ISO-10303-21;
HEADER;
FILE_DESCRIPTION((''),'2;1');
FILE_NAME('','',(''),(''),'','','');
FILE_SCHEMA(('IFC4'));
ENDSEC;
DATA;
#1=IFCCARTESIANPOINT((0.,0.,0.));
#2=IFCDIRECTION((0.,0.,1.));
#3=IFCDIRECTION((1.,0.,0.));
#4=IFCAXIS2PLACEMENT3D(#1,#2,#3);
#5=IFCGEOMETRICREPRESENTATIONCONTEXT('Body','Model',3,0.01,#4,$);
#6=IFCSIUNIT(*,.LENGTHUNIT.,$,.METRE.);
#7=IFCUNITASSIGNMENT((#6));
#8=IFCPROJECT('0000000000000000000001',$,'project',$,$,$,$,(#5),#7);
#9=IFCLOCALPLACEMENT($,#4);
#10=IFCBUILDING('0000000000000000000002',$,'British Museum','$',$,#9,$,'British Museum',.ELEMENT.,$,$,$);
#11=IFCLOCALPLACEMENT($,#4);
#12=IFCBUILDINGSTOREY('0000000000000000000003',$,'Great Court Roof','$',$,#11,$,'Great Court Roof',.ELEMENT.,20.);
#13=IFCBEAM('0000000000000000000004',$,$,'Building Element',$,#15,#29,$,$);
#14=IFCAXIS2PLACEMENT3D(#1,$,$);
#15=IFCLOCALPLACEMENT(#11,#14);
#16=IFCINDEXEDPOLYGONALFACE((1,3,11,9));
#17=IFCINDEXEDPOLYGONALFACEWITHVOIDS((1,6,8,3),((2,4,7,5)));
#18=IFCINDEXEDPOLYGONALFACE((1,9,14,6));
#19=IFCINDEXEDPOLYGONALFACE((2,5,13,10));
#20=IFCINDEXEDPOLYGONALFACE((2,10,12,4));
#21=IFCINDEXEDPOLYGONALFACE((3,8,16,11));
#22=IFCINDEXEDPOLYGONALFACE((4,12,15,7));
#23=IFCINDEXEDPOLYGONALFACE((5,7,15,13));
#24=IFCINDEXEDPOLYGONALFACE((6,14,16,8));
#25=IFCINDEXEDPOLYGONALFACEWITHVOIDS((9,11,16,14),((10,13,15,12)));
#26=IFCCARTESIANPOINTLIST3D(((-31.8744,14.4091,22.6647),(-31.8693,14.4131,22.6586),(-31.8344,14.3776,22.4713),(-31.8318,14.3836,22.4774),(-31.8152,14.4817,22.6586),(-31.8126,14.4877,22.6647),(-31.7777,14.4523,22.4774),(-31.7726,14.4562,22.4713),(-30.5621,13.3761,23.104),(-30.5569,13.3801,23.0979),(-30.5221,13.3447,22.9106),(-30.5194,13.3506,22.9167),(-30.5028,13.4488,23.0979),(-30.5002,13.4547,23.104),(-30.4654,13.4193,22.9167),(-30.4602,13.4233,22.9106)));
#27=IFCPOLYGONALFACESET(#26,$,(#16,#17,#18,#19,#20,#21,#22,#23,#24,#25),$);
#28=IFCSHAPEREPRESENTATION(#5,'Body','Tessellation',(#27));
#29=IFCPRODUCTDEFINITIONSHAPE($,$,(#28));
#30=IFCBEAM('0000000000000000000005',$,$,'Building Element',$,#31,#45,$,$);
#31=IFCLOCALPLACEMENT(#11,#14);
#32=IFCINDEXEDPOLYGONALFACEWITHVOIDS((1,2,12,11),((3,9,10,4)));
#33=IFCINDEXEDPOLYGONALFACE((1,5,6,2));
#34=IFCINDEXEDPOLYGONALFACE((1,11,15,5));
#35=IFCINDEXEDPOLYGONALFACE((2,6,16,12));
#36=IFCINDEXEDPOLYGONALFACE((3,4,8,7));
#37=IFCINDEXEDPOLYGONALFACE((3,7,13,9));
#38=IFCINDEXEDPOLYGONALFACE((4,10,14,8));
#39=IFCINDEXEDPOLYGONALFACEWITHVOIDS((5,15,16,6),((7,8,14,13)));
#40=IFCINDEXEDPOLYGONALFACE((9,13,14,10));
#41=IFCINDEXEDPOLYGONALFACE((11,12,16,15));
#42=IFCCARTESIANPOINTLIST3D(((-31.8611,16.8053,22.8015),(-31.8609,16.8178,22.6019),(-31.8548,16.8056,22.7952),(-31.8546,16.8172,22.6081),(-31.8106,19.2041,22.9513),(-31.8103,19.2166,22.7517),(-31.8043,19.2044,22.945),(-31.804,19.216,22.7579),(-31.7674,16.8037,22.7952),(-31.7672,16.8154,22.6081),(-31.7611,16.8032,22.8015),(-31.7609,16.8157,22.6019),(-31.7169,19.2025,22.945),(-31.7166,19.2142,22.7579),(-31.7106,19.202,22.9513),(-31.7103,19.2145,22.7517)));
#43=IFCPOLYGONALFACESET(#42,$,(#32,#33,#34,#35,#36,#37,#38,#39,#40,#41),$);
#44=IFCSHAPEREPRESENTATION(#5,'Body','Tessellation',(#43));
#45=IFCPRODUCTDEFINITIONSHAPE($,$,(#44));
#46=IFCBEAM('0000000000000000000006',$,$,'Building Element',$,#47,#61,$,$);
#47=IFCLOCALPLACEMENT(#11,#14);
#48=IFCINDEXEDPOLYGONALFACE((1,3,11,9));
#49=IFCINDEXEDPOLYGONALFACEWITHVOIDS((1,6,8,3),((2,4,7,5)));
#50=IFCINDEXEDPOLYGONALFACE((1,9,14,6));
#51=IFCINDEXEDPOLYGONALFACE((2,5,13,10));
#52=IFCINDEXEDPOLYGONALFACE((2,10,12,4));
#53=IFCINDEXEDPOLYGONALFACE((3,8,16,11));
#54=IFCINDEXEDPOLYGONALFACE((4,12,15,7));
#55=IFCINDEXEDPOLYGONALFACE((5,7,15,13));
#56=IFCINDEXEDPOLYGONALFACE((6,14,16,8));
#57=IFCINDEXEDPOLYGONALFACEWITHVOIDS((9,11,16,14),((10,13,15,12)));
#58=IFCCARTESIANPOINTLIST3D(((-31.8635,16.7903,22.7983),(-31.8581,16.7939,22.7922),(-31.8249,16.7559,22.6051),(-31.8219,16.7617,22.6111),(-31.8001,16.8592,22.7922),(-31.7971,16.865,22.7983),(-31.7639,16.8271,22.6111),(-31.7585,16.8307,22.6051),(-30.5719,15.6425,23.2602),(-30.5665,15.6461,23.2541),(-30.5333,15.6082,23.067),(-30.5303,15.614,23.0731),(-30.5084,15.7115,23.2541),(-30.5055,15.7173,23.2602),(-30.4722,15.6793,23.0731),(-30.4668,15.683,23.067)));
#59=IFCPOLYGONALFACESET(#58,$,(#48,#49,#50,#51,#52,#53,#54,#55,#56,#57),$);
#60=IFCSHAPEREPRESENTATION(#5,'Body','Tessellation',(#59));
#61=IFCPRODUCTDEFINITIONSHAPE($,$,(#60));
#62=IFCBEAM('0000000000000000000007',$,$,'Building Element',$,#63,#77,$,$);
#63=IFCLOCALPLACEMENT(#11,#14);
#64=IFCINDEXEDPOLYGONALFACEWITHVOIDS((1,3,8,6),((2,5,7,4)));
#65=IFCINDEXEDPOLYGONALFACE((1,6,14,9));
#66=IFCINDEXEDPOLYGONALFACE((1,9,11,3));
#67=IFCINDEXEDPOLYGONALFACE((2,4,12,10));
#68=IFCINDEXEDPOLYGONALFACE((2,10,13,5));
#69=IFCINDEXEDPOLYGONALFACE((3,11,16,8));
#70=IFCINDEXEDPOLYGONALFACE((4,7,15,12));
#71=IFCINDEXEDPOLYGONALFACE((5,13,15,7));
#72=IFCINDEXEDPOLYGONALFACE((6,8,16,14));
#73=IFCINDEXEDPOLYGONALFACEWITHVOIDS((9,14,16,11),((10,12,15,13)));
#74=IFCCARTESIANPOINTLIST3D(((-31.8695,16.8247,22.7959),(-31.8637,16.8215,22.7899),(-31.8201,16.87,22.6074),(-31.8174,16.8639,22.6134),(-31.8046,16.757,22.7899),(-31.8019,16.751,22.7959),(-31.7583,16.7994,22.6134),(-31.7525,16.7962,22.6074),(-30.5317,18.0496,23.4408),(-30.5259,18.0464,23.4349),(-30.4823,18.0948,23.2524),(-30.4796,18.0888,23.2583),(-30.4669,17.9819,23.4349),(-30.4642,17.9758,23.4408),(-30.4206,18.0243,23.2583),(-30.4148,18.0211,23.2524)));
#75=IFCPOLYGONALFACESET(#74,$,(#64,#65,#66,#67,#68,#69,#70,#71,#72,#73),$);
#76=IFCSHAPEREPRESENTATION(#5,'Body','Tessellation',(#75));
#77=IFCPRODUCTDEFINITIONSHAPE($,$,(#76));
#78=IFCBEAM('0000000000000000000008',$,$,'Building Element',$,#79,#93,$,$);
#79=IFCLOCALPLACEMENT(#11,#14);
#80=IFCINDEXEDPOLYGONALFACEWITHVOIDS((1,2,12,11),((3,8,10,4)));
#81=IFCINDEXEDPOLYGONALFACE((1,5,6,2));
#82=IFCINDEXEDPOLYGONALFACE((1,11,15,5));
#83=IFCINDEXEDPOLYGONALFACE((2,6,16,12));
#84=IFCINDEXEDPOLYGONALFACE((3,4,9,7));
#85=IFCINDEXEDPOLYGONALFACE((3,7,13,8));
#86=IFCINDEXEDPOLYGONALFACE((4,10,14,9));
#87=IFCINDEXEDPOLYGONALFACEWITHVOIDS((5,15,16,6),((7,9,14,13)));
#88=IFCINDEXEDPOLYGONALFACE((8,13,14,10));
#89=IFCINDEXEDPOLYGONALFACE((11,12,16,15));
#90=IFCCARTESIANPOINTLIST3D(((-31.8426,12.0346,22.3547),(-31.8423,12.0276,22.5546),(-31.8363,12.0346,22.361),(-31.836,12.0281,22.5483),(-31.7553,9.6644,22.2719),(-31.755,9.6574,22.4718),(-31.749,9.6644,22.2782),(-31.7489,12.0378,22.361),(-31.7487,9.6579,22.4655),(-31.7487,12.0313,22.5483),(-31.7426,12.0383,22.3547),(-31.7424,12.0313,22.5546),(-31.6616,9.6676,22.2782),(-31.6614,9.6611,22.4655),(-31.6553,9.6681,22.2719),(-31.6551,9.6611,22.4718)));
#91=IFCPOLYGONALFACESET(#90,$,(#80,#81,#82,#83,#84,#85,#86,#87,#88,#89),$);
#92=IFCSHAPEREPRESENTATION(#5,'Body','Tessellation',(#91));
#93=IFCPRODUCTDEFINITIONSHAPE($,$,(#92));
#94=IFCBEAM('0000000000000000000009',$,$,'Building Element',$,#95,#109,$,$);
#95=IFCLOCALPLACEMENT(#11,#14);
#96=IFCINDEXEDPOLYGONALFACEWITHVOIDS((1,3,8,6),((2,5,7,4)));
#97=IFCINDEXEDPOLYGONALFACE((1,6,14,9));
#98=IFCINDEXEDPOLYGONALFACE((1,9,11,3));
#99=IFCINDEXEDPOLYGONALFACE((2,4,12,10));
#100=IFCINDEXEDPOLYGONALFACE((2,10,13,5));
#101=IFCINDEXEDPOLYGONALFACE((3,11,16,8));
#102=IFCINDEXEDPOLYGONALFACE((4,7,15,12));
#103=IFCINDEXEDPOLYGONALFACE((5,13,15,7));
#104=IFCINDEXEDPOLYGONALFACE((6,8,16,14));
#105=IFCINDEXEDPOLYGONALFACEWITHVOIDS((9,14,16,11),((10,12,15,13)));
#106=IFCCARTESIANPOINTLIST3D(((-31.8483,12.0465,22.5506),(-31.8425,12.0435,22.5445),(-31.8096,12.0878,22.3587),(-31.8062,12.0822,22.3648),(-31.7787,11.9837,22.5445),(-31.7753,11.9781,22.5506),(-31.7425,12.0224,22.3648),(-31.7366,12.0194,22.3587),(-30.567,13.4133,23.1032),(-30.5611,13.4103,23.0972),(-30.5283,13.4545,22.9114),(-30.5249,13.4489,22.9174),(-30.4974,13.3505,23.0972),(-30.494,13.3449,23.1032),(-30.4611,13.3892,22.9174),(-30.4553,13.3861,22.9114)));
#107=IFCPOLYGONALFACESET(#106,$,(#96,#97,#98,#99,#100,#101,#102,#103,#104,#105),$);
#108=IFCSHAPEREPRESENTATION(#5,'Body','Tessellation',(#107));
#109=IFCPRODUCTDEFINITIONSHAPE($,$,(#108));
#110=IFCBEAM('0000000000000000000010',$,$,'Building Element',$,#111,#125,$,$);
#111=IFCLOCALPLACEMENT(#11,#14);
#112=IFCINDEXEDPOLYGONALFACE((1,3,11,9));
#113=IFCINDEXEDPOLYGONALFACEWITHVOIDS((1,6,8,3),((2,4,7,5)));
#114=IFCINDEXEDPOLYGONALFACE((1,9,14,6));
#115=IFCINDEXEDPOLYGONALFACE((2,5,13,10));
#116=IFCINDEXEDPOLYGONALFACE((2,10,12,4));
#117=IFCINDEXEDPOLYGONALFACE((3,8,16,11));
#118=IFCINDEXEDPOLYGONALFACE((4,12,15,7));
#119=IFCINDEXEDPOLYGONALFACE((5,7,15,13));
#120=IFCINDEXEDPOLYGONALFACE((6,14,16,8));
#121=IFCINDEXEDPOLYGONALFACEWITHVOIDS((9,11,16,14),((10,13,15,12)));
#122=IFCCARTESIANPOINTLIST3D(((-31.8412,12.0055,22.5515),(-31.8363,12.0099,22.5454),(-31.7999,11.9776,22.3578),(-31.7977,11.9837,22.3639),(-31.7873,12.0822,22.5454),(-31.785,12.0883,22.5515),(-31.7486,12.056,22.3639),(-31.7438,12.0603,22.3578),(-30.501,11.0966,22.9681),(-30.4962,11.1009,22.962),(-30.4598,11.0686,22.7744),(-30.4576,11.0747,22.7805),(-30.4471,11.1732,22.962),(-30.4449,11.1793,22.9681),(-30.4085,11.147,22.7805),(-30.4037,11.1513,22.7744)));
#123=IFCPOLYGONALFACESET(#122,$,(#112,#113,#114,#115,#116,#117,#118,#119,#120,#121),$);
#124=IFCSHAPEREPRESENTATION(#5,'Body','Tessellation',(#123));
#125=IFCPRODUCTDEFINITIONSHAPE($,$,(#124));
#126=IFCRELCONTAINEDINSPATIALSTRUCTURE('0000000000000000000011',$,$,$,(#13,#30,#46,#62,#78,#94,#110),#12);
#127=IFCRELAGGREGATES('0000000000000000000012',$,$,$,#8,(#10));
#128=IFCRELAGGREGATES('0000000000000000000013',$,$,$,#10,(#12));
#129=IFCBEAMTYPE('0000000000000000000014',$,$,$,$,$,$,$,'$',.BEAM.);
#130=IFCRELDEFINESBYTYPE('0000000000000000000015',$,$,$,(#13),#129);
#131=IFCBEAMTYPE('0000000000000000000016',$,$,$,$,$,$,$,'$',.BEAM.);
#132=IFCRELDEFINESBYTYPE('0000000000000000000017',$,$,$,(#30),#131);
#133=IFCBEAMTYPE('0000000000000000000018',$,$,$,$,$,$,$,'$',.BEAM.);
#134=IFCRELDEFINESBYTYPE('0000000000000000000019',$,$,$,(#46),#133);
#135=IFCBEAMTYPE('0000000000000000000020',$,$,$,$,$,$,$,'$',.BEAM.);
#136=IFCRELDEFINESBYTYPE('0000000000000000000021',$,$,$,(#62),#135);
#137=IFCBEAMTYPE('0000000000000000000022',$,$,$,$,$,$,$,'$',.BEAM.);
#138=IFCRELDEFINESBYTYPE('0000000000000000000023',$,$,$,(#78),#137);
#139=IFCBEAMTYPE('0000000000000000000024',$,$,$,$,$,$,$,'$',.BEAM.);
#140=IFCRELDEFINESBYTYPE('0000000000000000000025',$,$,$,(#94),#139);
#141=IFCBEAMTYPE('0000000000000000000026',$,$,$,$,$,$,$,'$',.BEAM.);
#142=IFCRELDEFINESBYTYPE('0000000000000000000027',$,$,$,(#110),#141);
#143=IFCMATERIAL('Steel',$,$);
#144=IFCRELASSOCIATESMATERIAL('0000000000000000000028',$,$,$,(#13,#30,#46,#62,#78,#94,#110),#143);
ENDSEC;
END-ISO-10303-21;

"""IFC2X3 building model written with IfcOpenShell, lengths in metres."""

from ifc_helpers import new_model, si_unit, frame, origin_with_axes, origin_2d, place, context, project, spatial, hollow_rectangle, extrude, material, type_object, element, save


model = new_model("IFC2X3")

# Units and contexts
model_context = context("Model", 3, precision=0.01, world=origin_with_axes(), identifier="Body")
ifc_project = project(units=[si_unit("LENGTHUNIT", "METRE")], contexts=[model_context])

# Building, storey
building_placement = place(None, origin_with_axes())
building = spatial("IfcBuilding", under=ifc_project, at=building_placement, Name="British Museum", Description="$", LongName="British Museum", CompositionType="ELEMENT")
storey_placement = place(None, origin_with_axes())
storey = spatial("IfcBuildingStorey", under=building, at=storey_placement, Name="Great Court Roof", Description="$", LongName="Great Court Roof", CompositionType="ELEMENT", Elevation=20.0)

# Beams
ifc_material = material(Name="Steel")
beam_type_1 = type_object("IfcBeamType", ElementType="$", PredefinedType="BEAM")
beam_1_placement = place(None, origin_with_axes())
element("IfcBeam", 1, at=beam_1_placement, inside=storey, type_object=beam_type_1, material=ifc_material, Description="Building Element", context=model_context, shape_type="SweptSolid", body=[
    extrude(hollow_rectangle(XDim=0.1, YDim=0.2, WallThickness=0.0063, InnerFilletRadius=-0.0063, OuterFilletRadius=0.0, at=origin_2d()), frame((-31.8235, 14.4327, 22.568), z_axis=(0.759942, -0.598145, 0.254385), x_axis=(0.618491, 0.785792, 0.0)), (0.0, 0.0, 1.0), 1.7269),
])
beam_type_2 = type_object("IfcBeamType", ElementType="$", PredefinedType="BEAM")
beam_2_placement = place(None, origin_with_axes())
element("IfcBeam", 2, at=beam_2_placement, inside=storey, type_object=beam_type_2, material=ifc_material, Description="Building Element", context=model_context, shape_type="SweptSolid", body=[
    extrude(hollow_rectangle(XDim=0.1, YDim=0.2, WallThickness=0.0063, InnerFilletRadius=-0.0063, OuterFilletRadius=0.0, at=origin_2d()), frame((-31.811, 16.8105, 22.7017), z_axis=(0.021026, 0.997835, 0.062314), x_axis=(-0.999778, 0.021067, 0.0)), (0.0, 0.0, 1.0), 2.404),
])
beam_type_3 = type_object("IfcBeamType", ElementType="$", PredefinedType="BEAM")
beam_3_placement = place(None, origin_with_axes())
element("IfcBeam", 3, at=beam_3_placement, inside=storey, type_object=beam_type_3, material=ifc_material, Description="Building Element", context=model_context, shape_type="SweptSolid", body=[
    extrude(hollow_rectangle(XDim=0.1, YDim=0.2, WallThickness=0.0063, InnerFilletRadius=-0.0063, OuterFilletRadius=0.0, at=origin_2d()), frame((-31.811, 16.8105, 22.7017), z_axis=(0.722158, -0.641702, 0.258276), x_axis=(0.664239, 0.74752, 0.0)), (0.0, 0.0, 1.0), 1.7886),
])
beam_type_4 = type_object("IfcBeamType", ElementType="$", PredefinedType="BEAM")
beam_4_placement = place(None, origin_with_axes())
element("IfcBeam", 4, at=beam_4_placement, inside=storey, type_object=beam_type_4, material=ifc_material, Description="Building Element", context=model_context, shape_type="SweptSolid", body=[
    extrude(hollow_rectangle(XDim=0.1, YDim=0.2, WallThickness=0.0063, InnerFilletRadius=-0.0063, OuterFilletRadius=0.0, at=origin_2d()), frame((-31.811, 16.8105, 22.7017), z_axis=(0.694921, 0.636276, 0.335019), x_axis=(-0.6753, 0.737543, 0.0)), (0.0, 0.0, 1.0), 1.925),
])
beam_type_5 = type_object("IfcBeamType", ElementType="$", PredefinedType="BEAM")
beam_5_placement = place(None, origin_with_axes())
element("IfcBeam", 5, at=beam_5_placement, inside=storey, type_object=beam_type_5, material=ifc_material, Description="Building Element", context=model_context, shape_type="SweptSolid", body=[
    extrude(hollow_rectangle(XDim=0.1, YDim=0.2, WallThickness=0.0063, InnerFilletRadius=-0.0063, OuterFilletRadius=0.0, at=origin_2d()), frame((-31.7925, 12.0329, 22.4546), z_axis=(0.036787, -0.998714, -0.03488), x_axis=(0.999322, 0.03681, 0.0)), (0.0, 0.0, 1.0), 2.3732),
])
beam_type_6 = type_object("IfcBeamType", ElementType="$", PredefinedType="BEAM")
beam_6_placement = place(None, origin_with_axes())
element("IfcBeam", 6, at=beam_6_placement, inside=storey, type_object=beam_type_6, material=ifc_material, Description="Building Element", context=model_context, shape_type="SweptSolid", body=[
    extrude(hollow_rectangle(XDim=0.1, YDim=0.2, WallThickness=0.0063, InnerFilletRadius=-0.0063, OuterFilletRadius=0.0, at=origin_2d()), frame((-31.7925, 12.0329, 22.4546), z_axis=(0.655988, 0.699736, 0.28293), x_axis=(-0.729545, 0.683933, 0.0)), (0.0, 0.0, 1.0), 1.9533),
])
beam_type_7 = type_object("IfcBeamType", ElementType="$", PredefinedType="BEAM")
beam_7_placement = place(None, origin_with_axes())
element("IfcBeam", 7, at=beam_7_placement, inside=storey, type_object=beam_type_7, material=ifc_material, Description="Building Element", context=model_context, shape_type="SweptSolid", body=[
    extrude(hollow_rectangle(XDim=0.1, YDim=0.2, WallThickness=0.0063, InnerFilletRadius=-0.0063, OuterFilletRadius=0.0, at=origin_2d()), frame((-31.7925, 12.0329, 22.4546), z_axis=(0.801488, -0.543627, 0.249173), x_axis=(0.561332, 0.827591, 0.0)), (0.0, 0.0, 1.0), 1.672),
])

save(model, "model.ifc")
